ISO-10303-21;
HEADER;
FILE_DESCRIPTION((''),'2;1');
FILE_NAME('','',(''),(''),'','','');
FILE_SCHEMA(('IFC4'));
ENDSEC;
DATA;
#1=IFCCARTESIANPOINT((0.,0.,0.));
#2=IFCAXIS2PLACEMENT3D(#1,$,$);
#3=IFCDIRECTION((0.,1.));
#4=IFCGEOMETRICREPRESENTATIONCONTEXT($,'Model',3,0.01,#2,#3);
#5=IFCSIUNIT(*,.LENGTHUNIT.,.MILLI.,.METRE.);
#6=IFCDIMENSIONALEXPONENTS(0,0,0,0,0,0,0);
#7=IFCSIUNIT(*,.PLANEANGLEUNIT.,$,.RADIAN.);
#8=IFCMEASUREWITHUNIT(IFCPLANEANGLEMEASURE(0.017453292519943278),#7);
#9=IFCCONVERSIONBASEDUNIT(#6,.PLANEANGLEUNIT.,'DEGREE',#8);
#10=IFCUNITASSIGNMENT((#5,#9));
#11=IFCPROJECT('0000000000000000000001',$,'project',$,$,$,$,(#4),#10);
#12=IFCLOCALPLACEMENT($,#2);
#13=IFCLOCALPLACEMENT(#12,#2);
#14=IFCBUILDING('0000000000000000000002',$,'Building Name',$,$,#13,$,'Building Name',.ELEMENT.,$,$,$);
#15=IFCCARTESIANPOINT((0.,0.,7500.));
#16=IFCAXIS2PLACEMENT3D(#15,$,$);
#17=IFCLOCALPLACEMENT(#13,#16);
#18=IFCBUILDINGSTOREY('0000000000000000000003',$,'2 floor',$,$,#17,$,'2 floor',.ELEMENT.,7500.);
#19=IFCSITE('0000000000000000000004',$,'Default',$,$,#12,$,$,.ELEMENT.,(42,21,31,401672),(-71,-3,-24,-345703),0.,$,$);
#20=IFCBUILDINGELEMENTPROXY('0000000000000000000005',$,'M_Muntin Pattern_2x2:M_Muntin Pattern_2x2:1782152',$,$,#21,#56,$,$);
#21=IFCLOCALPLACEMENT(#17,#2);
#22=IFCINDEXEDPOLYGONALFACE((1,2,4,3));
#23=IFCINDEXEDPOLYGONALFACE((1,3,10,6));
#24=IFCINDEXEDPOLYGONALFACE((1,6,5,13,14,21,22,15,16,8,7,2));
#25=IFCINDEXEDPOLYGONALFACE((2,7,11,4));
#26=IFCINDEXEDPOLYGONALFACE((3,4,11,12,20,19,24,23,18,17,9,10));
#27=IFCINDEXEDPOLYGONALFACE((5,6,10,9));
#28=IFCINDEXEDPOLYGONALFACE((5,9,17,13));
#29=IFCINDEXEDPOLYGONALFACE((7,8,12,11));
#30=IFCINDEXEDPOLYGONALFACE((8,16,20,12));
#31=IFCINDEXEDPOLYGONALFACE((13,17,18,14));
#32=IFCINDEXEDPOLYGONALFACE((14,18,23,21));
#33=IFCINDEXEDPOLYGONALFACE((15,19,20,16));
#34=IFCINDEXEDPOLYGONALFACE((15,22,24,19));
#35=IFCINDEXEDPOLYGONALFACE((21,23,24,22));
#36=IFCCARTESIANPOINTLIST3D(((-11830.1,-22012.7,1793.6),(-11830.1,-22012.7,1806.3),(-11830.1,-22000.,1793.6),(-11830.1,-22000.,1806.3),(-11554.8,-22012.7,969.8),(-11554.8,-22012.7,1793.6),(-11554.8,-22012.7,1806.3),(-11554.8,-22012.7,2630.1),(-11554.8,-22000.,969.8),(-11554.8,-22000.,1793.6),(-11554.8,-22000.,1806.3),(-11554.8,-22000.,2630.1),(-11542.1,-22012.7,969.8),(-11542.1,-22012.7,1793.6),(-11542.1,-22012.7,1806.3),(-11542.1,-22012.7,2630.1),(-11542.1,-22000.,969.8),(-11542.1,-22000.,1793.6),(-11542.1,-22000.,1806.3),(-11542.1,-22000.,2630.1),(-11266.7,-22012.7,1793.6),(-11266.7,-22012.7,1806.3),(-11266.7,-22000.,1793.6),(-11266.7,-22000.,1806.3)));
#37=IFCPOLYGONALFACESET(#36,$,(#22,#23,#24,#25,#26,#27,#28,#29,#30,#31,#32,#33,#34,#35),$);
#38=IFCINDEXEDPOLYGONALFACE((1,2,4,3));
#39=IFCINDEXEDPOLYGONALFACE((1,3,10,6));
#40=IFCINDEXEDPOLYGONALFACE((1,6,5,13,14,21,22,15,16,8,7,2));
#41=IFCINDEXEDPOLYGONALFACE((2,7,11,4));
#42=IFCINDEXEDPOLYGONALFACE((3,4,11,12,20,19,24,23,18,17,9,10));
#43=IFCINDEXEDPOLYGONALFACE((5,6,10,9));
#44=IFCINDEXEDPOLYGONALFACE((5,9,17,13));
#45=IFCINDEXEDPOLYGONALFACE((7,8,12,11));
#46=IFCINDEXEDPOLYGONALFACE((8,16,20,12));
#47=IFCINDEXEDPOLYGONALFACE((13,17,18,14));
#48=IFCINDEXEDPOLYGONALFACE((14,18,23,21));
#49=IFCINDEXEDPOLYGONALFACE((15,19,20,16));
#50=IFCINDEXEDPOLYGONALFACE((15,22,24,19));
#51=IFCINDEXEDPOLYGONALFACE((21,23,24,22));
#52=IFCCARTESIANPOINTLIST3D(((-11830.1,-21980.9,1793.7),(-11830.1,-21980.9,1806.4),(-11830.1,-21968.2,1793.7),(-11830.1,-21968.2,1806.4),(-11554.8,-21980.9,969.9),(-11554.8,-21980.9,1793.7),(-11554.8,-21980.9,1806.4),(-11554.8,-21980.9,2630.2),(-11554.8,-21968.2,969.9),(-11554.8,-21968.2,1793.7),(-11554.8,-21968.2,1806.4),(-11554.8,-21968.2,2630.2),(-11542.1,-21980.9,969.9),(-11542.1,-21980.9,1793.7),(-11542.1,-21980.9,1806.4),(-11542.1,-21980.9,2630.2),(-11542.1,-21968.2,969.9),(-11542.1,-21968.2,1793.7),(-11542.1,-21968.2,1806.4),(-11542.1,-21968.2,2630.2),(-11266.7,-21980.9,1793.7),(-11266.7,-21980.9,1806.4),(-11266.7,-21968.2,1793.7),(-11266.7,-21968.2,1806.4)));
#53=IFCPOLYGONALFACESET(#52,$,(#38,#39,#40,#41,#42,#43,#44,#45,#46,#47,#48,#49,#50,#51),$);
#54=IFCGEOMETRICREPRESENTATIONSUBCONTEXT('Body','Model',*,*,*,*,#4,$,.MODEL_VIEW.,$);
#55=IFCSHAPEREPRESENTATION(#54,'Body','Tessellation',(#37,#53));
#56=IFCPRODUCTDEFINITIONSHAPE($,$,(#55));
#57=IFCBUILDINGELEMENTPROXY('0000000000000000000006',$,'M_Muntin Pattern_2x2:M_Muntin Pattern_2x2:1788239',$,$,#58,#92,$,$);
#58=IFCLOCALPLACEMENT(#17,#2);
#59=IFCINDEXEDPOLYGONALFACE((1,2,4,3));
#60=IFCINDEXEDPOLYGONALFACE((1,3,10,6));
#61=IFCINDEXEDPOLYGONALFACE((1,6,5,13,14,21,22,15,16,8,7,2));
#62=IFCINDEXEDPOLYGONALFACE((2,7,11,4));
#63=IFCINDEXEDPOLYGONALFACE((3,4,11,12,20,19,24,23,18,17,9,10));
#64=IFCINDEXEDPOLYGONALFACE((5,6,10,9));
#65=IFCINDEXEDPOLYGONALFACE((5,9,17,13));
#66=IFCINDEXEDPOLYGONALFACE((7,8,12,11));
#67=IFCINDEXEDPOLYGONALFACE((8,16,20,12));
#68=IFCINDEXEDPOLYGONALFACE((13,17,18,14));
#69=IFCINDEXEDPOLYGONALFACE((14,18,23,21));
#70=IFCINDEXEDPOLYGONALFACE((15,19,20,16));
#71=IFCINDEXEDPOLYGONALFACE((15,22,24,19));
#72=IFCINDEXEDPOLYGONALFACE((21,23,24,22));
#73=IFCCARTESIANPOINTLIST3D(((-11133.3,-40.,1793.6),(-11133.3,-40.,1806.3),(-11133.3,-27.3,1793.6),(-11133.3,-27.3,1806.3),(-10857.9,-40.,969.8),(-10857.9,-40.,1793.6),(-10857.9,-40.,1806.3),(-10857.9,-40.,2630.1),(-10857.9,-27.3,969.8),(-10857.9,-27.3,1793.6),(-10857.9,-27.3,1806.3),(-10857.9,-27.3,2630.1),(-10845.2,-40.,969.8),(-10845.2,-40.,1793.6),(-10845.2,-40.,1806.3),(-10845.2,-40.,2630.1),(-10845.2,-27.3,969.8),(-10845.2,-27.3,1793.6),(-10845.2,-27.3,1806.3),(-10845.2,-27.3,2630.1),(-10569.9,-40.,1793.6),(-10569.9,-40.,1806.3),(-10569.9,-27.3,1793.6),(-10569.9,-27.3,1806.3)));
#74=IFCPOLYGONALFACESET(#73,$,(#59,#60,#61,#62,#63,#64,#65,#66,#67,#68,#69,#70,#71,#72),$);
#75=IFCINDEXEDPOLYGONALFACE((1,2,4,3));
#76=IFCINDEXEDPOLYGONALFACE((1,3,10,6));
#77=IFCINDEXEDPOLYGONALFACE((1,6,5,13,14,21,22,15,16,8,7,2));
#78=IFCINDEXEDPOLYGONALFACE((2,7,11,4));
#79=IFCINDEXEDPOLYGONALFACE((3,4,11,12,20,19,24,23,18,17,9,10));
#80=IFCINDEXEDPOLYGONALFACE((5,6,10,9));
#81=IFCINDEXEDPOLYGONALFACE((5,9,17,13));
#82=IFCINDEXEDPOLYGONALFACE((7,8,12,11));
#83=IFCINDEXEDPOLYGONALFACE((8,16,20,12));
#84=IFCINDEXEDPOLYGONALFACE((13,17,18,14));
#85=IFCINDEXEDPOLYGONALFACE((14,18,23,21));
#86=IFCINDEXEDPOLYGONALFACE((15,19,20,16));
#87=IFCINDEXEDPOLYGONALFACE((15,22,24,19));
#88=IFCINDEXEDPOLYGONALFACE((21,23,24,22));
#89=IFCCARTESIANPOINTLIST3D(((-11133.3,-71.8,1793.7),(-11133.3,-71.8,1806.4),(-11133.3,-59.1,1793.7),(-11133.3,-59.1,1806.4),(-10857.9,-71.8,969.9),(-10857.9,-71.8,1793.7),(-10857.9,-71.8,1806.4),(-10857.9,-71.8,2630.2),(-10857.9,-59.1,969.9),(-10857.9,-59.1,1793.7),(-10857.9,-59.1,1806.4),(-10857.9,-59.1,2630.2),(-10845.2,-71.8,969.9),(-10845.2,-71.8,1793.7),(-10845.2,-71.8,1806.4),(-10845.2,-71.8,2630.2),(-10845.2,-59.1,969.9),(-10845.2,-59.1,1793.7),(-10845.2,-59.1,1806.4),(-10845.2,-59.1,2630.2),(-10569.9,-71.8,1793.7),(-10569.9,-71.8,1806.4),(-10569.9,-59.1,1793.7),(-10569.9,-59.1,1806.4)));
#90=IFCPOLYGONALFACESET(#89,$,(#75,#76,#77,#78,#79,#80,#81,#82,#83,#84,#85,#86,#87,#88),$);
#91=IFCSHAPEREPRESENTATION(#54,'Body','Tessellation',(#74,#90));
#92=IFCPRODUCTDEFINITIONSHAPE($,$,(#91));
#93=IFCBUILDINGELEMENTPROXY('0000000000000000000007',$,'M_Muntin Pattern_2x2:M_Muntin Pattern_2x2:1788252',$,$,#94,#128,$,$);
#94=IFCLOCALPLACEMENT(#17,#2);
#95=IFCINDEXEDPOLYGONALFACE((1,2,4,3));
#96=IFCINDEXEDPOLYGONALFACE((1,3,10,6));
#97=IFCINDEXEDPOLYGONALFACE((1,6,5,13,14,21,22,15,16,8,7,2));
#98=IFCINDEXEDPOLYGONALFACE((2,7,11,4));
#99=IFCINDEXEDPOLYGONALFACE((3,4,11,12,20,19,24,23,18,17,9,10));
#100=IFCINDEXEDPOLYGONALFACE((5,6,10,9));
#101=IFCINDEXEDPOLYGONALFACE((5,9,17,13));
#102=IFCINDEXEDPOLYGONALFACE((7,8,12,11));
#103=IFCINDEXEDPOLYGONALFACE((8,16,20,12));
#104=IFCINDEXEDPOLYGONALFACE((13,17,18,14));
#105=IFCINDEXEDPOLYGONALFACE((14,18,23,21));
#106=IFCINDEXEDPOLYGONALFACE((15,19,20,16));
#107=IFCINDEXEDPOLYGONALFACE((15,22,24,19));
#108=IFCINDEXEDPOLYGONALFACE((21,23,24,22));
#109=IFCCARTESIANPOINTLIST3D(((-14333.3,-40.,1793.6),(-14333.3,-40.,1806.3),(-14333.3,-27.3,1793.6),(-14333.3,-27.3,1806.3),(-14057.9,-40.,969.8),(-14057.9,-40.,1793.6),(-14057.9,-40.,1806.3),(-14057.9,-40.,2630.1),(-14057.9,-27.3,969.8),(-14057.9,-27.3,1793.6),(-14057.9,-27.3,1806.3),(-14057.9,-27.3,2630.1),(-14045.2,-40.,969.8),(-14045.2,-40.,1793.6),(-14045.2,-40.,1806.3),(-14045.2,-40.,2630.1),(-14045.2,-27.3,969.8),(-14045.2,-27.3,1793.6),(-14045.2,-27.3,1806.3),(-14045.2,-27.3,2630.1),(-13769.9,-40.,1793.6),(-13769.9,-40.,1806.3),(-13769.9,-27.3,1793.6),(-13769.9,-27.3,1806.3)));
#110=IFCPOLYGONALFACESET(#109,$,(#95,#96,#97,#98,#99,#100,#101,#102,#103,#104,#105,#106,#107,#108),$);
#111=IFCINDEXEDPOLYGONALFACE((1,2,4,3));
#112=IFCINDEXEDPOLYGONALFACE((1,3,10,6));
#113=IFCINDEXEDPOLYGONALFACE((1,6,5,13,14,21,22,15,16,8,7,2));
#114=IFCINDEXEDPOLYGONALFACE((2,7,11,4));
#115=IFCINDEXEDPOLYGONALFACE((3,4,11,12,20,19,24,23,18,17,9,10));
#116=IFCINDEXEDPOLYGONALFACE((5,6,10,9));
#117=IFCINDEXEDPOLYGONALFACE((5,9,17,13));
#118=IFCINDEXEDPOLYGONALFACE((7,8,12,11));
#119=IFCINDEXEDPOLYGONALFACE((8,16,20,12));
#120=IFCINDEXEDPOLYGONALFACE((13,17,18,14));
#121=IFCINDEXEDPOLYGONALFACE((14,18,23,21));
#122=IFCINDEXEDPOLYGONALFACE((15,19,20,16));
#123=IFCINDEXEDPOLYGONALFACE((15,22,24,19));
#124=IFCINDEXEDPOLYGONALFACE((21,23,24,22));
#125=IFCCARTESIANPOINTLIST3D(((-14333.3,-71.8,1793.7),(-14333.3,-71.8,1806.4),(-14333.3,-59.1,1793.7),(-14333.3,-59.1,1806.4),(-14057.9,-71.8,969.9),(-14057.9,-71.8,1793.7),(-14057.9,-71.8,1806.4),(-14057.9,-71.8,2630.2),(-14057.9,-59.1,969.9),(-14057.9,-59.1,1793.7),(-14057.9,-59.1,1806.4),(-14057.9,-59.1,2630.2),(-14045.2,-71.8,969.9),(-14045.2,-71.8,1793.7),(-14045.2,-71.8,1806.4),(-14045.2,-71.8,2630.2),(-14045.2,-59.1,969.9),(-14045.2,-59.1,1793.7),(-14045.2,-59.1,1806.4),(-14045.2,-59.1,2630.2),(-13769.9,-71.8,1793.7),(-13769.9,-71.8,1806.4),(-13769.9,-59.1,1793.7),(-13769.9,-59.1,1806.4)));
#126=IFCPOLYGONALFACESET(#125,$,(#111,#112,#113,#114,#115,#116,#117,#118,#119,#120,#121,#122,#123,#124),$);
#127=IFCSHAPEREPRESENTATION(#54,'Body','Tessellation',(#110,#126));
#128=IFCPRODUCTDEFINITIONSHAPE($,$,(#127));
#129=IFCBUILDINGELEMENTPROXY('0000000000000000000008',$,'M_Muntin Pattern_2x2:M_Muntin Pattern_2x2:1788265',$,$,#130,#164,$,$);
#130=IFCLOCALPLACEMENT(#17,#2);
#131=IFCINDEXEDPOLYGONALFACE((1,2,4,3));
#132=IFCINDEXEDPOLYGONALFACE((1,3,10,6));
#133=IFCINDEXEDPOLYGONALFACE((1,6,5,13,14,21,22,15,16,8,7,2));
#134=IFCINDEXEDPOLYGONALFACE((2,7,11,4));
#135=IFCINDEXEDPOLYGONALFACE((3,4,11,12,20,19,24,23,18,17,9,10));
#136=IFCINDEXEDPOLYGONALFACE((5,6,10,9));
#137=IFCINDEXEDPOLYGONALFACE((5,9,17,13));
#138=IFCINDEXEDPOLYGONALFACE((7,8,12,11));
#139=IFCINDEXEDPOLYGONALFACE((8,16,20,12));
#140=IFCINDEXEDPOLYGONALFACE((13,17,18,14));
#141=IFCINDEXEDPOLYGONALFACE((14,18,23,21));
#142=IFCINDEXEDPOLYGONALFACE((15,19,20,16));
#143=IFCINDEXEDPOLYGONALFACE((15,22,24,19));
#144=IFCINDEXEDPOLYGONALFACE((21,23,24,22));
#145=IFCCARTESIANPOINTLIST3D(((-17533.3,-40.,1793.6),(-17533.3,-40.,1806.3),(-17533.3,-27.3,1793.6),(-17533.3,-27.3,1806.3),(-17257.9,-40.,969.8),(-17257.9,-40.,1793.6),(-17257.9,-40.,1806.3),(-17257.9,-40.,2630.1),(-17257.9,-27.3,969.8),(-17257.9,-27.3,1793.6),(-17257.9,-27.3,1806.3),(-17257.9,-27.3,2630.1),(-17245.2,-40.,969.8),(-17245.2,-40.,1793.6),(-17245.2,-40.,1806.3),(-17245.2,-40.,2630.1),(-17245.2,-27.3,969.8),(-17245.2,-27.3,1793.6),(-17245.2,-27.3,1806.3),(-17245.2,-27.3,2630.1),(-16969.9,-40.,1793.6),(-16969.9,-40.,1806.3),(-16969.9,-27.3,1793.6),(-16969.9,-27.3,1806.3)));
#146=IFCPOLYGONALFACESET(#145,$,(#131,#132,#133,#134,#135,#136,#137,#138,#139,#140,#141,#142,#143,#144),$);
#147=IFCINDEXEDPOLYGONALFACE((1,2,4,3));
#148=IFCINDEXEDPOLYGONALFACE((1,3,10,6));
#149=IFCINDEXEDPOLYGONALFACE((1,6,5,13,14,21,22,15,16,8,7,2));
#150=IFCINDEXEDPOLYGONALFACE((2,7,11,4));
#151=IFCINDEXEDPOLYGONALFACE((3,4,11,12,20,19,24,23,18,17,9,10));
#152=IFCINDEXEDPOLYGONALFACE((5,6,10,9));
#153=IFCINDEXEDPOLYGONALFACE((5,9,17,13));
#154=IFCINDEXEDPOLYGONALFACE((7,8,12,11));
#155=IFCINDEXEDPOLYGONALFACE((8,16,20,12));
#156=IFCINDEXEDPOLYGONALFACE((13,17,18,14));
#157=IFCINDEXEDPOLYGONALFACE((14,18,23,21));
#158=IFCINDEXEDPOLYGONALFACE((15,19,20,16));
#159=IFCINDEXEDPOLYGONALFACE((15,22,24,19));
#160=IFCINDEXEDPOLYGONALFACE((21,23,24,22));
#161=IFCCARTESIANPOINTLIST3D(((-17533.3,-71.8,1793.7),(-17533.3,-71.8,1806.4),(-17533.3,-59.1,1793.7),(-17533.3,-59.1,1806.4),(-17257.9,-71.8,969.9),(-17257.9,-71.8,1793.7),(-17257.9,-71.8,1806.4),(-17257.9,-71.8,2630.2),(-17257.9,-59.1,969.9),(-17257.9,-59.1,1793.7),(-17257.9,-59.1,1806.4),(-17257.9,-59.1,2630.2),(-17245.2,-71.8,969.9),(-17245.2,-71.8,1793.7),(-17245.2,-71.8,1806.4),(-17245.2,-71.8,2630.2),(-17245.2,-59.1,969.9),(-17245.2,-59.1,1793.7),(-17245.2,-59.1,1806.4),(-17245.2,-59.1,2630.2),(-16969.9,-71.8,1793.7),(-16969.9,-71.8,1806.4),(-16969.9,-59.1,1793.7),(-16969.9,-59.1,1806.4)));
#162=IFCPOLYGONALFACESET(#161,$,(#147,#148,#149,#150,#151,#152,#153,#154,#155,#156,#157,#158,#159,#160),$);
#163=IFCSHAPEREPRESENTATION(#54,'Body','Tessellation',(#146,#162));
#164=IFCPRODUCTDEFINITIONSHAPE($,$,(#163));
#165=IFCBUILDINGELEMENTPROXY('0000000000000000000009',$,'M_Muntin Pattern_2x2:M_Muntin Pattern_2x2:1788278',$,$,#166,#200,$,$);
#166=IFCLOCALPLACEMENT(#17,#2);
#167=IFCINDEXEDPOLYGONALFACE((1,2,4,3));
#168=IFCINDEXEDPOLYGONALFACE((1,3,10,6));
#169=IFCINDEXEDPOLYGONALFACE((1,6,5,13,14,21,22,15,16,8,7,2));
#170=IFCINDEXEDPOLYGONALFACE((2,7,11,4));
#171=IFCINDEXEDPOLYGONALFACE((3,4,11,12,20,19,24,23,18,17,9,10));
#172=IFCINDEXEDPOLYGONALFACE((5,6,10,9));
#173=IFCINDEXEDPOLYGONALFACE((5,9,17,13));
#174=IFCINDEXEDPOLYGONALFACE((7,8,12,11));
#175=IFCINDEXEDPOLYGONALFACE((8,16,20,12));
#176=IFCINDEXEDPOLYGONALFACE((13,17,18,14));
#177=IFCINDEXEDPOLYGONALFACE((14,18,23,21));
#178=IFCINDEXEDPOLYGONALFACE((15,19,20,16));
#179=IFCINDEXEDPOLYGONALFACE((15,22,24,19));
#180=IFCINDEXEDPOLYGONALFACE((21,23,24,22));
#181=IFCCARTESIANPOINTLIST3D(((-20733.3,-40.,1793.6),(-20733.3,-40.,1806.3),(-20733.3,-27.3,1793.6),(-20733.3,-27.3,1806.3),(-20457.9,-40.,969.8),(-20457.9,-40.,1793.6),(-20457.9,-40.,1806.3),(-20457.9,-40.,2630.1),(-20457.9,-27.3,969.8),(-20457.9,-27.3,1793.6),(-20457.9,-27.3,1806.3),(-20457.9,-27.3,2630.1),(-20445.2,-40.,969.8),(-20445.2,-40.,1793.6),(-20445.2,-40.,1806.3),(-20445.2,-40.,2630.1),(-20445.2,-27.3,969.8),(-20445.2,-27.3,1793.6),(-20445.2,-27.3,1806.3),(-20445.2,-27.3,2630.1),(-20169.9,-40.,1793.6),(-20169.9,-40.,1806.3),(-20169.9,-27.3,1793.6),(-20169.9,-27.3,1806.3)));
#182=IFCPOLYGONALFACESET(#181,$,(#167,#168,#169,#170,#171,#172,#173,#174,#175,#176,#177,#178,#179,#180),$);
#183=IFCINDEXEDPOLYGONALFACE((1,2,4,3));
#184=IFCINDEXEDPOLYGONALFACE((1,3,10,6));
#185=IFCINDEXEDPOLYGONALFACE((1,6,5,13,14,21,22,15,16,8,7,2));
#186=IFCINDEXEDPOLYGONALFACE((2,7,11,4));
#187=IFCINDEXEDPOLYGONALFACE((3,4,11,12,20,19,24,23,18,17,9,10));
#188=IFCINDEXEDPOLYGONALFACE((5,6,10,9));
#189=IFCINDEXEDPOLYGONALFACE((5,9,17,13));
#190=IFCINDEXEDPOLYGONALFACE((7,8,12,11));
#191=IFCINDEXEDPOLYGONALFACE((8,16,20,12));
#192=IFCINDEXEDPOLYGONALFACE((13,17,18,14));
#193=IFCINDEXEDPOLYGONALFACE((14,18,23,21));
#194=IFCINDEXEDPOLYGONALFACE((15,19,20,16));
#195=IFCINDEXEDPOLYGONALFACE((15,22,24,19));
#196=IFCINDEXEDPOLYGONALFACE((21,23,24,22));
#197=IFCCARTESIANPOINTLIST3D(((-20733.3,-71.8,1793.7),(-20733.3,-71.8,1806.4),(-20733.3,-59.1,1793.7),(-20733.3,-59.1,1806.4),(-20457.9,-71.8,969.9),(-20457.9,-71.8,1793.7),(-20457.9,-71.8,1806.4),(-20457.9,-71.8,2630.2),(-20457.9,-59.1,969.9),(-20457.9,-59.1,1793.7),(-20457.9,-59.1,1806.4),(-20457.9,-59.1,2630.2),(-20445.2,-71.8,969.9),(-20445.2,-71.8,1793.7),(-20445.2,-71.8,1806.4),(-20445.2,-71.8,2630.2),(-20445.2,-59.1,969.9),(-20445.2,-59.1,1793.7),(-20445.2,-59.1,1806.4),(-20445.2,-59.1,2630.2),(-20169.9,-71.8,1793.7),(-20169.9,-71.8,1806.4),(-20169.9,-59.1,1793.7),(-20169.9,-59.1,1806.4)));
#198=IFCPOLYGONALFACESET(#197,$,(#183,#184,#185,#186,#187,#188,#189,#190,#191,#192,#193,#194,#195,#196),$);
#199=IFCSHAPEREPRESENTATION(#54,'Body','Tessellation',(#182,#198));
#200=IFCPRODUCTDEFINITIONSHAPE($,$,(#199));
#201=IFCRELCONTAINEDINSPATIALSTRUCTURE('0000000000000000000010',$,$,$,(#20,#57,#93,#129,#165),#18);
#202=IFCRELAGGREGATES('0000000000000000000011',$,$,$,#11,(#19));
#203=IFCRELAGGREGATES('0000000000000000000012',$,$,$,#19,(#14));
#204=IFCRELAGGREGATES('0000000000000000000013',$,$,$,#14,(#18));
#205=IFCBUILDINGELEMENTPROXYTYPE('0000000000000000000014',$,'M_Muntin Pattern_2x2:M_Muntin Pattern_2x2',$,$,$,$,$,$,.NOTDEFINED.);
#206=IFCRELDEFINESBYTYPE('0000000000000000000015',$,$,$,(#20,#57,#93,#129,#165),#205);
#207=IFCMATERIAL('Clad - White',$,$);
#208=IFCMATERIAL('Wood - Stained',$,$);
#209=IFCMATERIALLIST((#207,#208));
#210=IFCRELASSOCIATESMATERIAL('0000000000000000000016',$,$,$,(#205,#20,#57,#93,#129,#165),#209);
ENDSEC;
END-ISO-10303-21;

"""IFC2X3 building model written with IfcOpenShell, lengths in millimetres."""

from ifc_helpers import new_model, entity, si_unit, converted_unit, direction, frame, origin, place, context, subcontext, project, spatial, polyline, outline, extrude, source, transform, mapped, material, material_list, type_object, type_shapes, element, save


model = new_model("IFC2X3")

# Units and contexts
model_context = context("Model", 3, precision=0.01, world=origin(), true_north=direction((0.0, 1.0)))
body_context = subcontext(model_context, "Body", "Model", "MODEL_VIEW")
ifc_project = project(units=[si_unit("LENGTHUNIT", "METRE", prefix="MILLI"), converted_unit("PLANEANGLEUNIT", "DEGREE", entity("IfcPlaneAngleMeasure", 0.017453292519943278), si_unit("PLANEANGLEUNIT", "RADIAN"), dimensions=[0, 0, 0, 0, 0, 0, 0])], contexts=[model_context])

# Site, building, storey
site_placement = place(None, origin())
site = spatial("IfcSite", under=ifc_project, at=site_placement, Name="Default", CompositionType="ELEMENT", RefLatitude=(42, 21, 31, 401672), RefLongitude=(-71, -3, -24, -345703), RefElevation=0.0)
building_placement = place(site_placement, origin())
building = spatial("IfcBuilding", under=site, at=building_placement, Name="Building Name", LongName="Building Name", CompositionType="ELEMENT")
storey_placement = place(building_placement, frame((0.0, 0.0, 7500.0)))
storey = spatial("IfcBuildingStorey", under=building, at=storey_placement, Name="2 floor", LongName="2 floor", CompositionType="ELEMENT", Elevation=7500.0)

# Building element proxies
ifc_material_1 = material(Name="Clad - White")
ifc_material_2 = material(Name="Wood - Stained")
ifc_material_list = material_list([ifc_material_1, ifc_material_2])
building_element_proxy_type_1 = type_object("IfcBuildingElementProxyType", Name="M_Muntin Pattern_2x2:M_Muntin Pattern_2x2", PredefinedType="NOTDEFINED", material=ifc_material_list)
shared_shape_1 = source(origin(), body_context, "Body", "SweptSolid", [
    extrude(outline(polyline([(6.4, -6.4), (830.1, -6.4), (830.1, 6.3), (6.4, 6.3), (6.4, 281.7), (-6.3, 281.7), (-6.3, 6.3), (-830.2, 6.3), (-830.2, -6.4), (-6.3, -6.4), (-6.3, -281.7), (6.4, -281.7), (6.4, -6.4)])), frame((0.0, -22.2, 830.1), z_axis=(0.0, 1.0, 0.0), x_axis=(0.0, 0.0, 1.0)), (0.0, 0.0, 1.0), 12.7),
    extrude(outline(polyline([(6.4, -6.4), (830.2, -6.4), (830.2, 6.3), (6.4, 6.3), (6.4, 281.7), (-6.3, 281.7), (-6.3, 6.3), (-830.2, 6.3), (-830.2, -6.4), (-6.3, -6.4), (-6.3, -281.7), (6.4, -281.7), (6.4, -6.4)])), frame((0.0, 9.5, 830.2), z_axis=(0.0, 1.0, 0.0), x_axis=(0.0, 0.0, 1.0)), (0.0, 0.0, 1.0), 12.7),
])
type_shapes(building_element_proxy_type_1, [shared_shape_1])
for number, where, name in (
    (1, (-11548.4, -21990.5, 969.9), "M_Muntin Pattern_2x2:M_Muntin Pattern_2x2:1782152"),
):
    element("IfcBuildingElementProxy", number, at=place(storey_placement, frame(where)), inside=storey, type_object=building_element_proxy_type_1, material=ifc_material_list, Name=name, context=body_context, shape_type="MappedRepresentation", body=[
        mapped(shared_shape_1, transform((0.0, 0.0, 0.0), scale=1.0)),
    ])
for number, where, z_axis, x_axis, name in (
    (2, (-10851.6, -49.5, 969.9), (0.0, 0.0, 1.0), (-1.0, 0.0, 0.0), "M_Muntin Pattern_2x2:M_Muntin Pattern_2x2:1788239"),
    (3, (-14051.6, -49.5, 969.9), (0.0, 0.0, 1.0), (-1.0, 0.0, 0.0), "M_Muntin Pattern_2x2:M_Muntin Pattern_2x2:1788252"),
    (4, (-17251.6, -49.5, 969.9), (0.0, 0.0, 1.0), (-1.0, 0.0, 0.0), "M_Muntin Pattern_2x2:M_Muntin Pattern_2x2:1788265"),
    (5, (-20451.6, -49.5, 969.9), (0.0, 0.0, 1.0), (-1.0, 0.0, 0.0), "M_Muntin Pattern_2x2:M_Muntin Pattern_2x2:1788278"),
):
    element("IfcBuildingElementProxy", number, at=place(storey_placement, frame(where, z_axis=z_axis, x_axis=x_axis)), inside=storey, type_object=building_element_proxy_type_1, material=ifc_material_list, Name=name, context=body_context, shape_type="MappedRepresentation", body=[
        mapped(shared_shape_1, transform((0.0, 0.0, 0.0), scale=1.0)),
    ])

save(model, "model.ifc")
